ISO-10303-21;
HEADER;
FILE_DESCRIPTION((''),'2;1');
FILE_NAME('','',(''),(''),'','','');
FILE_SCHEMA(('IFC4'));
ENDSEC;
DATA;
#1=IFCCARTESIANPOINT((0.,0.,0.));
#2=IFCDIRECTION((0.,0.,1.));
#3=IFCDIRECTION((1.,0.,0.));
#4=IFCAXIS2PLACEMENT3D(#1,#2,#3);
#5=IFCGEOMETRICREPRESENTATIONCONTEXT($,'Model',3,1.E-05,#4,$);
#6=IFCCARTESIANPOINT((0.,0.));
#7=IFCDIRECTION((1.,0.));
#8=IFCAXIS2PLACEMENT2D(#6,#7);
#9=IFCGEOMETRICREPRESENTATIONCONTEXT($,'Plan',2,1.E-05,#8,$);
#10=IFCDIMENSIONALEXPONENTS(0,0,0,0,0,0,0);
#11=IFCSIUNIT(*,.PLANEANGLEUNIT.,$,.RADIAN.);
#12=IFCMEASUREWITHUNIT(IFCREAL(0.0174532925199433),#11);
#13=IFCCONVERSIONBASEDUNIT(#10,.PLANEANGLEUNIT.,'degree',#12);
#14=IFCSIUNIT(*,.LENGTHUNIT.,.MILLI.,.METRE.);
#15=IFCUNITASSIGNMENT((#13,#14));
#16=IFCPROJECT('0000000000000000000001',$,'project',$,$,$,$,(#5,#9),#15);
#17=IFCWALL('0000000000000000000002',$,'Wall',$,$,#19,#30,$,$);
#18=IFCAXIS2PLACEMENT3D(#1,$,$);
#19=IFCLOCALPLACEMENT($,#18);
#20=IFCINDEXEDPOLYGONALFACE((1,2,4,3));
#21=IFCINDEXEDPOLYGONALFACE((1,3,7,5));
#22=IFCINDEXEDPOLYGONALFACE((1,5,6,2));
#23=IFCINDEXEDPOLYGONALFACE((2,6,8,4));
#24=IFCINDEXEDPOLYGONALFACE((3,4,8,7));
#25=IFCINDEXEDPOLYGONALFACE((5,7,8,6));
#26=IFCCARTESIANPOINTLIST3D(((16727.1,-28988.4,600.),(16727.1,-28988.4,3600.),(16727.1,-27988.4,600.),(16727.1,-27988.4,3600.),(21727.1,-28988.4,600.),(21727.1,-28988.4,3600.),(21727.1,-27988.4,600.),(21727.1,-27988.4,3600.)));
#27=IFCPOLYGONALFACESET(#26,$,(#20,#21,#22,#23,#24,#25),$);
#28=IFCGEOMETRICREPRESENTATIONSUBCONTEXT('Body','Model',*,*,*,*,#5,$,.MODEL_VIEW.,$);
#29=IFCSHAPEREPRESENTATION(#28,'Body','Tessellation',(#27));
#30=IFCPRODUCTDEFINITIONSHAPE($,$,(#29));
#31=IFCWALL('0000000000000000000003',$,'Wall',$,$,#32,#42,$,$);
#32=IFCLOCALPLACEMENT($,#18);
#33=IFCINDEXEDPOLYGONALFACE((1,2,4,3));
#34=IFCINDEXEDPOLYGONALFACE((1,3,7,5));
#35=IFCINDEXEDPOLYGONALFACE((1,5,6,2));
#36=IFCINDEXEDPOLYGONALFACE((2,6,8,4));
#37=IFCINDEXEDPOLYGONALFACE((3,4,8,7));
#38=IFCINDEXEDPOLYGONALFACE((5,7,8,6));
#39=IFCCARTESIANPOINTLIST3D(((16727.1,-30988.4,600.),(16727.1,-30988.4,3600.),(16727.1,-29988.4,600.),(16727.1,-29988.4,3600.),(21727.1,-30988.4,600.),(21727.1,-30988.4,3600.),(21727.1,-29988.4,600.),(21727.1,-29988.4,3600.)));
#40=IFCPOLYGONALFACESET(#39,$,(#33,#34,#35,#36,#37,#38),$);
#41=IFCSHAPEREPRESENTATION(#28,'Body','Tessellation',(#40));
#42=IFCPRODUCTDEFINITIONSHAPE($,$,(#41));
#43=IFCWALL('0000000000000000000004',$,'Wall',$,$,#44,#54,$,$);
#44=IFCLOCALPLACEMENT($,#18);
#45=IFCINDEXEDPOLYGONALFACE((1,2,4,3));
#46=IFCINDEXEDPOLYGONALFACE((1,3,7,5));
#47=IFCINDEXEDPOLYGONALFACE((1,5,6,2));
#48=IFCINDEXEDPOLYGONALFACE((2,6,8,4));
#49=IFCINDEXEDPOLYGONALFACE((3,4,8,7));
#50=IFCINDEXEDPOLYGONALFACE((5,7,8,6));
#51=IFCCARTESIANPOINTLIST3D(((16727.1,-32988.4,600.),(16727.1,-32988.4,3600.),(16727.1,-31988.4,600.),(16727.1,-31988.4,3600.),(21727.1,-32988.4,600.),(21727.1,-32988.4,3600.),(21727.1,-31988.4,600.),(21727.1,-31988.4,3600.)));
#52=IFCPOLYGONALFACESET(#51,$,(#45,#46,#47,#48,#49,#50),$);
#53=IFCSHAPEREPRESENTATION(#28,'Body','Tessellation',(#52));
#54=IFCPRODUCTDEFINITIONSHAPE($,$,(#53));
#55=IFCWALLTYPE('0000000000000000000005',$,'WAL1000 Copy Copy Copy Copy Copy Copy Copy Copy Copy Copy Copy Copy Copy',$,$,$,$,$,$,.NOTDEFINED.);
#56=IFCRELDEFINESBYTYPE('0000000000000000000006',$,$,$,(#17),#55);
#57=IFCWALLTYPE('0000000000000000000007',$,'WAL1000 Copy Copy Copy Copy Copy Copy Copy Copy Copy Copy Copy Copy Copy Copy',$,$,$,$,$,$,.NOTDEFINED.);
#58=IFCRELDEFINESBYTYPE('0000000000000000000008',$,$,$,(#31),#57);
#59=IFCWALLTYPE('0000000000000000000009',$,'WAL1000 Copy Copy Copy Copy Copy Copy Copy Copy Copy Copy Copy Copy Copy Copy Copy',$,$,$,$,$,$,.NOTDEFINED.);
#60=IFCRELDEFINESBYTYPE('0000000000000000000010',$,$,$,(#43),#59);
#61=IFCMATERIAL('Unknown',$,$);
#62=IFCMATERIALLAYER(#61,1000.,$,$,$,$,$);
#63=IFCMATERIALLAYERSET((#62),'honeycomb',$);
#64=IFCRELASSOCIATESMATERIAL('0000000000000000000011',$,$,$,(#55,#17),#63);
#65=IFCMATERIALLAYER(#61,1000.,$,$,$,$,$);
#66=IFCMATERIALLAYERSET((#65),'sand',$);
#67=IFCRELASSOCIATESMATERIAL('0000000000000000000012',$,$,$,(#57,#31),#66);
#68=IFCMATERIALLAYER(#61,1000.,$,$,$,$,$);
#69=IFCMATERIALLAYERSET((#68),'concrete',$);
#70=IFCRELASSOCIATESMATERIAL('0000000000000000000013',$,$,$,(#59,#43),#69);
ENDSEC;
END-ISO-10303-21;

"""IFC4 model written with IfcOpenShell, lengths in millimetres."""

from ifc_helpers import new_model, entity, si_unit, converted_unit, frame, origin_with_axes, origin_2d_with_axis, place, context, subcontext, project, indexed_curve, outline, extrude, material, layer, layer_set, layer_usage, type_object, element, save


model = new_model("IFC4")

# Units and contexts
model_context = context("Model", 3, precision=1e-05, world=origin_with_axes())
plan_context = context("Plan", 2, precision=1e-05, world=origin_2d_with_axis())
body_context = subcontext(model_context, "Body", "Model", "MODEL_VIEW")
ifc_project = project(units=[converted_unit("PLANEANGLEUNIT", "degree", entity("IfcReal", 0.0174532925199433), si_unit("PLANEANGLEUNIT", "RADIAN"), dimensions=[0, 0, 0, 0, 0, 0, 0]), si_unit("LENGTHUNIT", "METRE", prefix="MILLI")], contexts=[model_context, plan_context])

# Walls
ifc_material = material(Name="Unknown")
ifc_layer_1 = layer(ifc_material, 1000.0)
ifc_layer_set_1 = layer_set([ifc_layer_1], Name="honeycomb")
ifc_layer_usage_1 = layer_usage(ifc_layer_set_1, "AXIS2", "POSITIVE", 0.0)
wall_type_1 = type_object("IfcWallType", Name="WAL1000 Copy Copy Copy Copy Copy Copy Copy Copy Copy Copy Copy Copy Copy", PredefinedType="NOTDEFINED", material=ifc_layer_set_1)
wall_1_placement = place(None, frame((16727.1, -28988.4, 600.0), z_axis=(0.0, 0.0, 1.0), x_axis=(1.0, 0.0, 0.0)))
element("IfcWall", 1, at=wall_1_placement, type_object=wall_type_1, material=ifc_layer_usage_1, Name="Wall", context=body_context, shape_type="SweptSolid", body=[
    extrude(outline(indexed_curve([(0.0, 0.0), (0.0, 1000.0), (5000.0, 1000.0), (5000.0, 0.0), (0.0, 0.0)], self_intersect=False)), origin_with_axes(), (0.0, 0.0, 1.0), 3000.0),
])
ifc_layer_2 = layer(ifc_material, 1000.0)
ifc_layer_set_2 = layer_set([ifc_layer_2], Name="sand")
ifc_layer_usage_2 = layer_usage(ifc_layer_set_2, "AXIS2", "POSITIVE", 0.0)
wall_type_2 = type_object("IfcWallType", Name="WAL1000 Copy Copy Copy Copy Copy Copy Copy Copy Copy Copy Copy Copy Copy Copy", PredefinedType="NOTDEFINED", material=ifc_layer_set_2)
wall_2_placement = place(None, frame((16727.1, -30988.4, 600.0), z_axis=(0.0, 0.0, 1.0), x_axis=(1.0, 0.0, 0.0)))
element("IfcWall", 2, at=wall_2_placement, type_object=wall_type_2, material=ifc_layer_usage_2, Name="Wall", context=body_context, shape_type="SweptSolid", body=[
    extrude(outline(indexed_curve([(0.0, 0.0), (0.0, 1000.0), (5000.0, 1000.0), (5000.0, 0.0), (0.0, 0.0)], self_intersect=False)), origin_with_axes(), (0.0, 0.0, 1.0), 3000.0),
])
ifc_layer_3 = layer(ifc_material, 1000.0)
ifc_layer_set_3 = layer_set([ifc_layer_3], Name="concrete")
ifc_layer_usage_3 = layer_usage(ifc_layer_set_3, "AXIS2", "POSITIVE", 0.0)
wall_type_3 = type_object("IfcWallType", Name="WAL1000 Copy Copy Copy Copy Copy Copy Copy Copy Copy Copy Copy Copy Copy Copy Copy", PredefinedType="NOTDEFINED", material=ifc_layer_set_3)
wall_3_placement = place(None, frame((16727.1, -32988.4, 600.0), z_axis=(0.0, 0.0, 1.0), x_axis=(1.0, 0.0, 0.0)))
element("IfcWall", 3, at=wall_3_placement, type_object=wall_type_3, material=ifc_layer_usage_3, Name="Wall", context=body_context, shape_type="SweptSolid", body=[
    extrude(outline(indexed_curve([(0.0, 0.0), (0.0, 1000.0), (5000.0, 1000.0), (5000.0, 0.0), (0.0, 0.0)], self_intersect=False)), origin_with_axes(), (0.0, 0.0, 1.0), 3000.0),
])

save(model, "model.ifc")
